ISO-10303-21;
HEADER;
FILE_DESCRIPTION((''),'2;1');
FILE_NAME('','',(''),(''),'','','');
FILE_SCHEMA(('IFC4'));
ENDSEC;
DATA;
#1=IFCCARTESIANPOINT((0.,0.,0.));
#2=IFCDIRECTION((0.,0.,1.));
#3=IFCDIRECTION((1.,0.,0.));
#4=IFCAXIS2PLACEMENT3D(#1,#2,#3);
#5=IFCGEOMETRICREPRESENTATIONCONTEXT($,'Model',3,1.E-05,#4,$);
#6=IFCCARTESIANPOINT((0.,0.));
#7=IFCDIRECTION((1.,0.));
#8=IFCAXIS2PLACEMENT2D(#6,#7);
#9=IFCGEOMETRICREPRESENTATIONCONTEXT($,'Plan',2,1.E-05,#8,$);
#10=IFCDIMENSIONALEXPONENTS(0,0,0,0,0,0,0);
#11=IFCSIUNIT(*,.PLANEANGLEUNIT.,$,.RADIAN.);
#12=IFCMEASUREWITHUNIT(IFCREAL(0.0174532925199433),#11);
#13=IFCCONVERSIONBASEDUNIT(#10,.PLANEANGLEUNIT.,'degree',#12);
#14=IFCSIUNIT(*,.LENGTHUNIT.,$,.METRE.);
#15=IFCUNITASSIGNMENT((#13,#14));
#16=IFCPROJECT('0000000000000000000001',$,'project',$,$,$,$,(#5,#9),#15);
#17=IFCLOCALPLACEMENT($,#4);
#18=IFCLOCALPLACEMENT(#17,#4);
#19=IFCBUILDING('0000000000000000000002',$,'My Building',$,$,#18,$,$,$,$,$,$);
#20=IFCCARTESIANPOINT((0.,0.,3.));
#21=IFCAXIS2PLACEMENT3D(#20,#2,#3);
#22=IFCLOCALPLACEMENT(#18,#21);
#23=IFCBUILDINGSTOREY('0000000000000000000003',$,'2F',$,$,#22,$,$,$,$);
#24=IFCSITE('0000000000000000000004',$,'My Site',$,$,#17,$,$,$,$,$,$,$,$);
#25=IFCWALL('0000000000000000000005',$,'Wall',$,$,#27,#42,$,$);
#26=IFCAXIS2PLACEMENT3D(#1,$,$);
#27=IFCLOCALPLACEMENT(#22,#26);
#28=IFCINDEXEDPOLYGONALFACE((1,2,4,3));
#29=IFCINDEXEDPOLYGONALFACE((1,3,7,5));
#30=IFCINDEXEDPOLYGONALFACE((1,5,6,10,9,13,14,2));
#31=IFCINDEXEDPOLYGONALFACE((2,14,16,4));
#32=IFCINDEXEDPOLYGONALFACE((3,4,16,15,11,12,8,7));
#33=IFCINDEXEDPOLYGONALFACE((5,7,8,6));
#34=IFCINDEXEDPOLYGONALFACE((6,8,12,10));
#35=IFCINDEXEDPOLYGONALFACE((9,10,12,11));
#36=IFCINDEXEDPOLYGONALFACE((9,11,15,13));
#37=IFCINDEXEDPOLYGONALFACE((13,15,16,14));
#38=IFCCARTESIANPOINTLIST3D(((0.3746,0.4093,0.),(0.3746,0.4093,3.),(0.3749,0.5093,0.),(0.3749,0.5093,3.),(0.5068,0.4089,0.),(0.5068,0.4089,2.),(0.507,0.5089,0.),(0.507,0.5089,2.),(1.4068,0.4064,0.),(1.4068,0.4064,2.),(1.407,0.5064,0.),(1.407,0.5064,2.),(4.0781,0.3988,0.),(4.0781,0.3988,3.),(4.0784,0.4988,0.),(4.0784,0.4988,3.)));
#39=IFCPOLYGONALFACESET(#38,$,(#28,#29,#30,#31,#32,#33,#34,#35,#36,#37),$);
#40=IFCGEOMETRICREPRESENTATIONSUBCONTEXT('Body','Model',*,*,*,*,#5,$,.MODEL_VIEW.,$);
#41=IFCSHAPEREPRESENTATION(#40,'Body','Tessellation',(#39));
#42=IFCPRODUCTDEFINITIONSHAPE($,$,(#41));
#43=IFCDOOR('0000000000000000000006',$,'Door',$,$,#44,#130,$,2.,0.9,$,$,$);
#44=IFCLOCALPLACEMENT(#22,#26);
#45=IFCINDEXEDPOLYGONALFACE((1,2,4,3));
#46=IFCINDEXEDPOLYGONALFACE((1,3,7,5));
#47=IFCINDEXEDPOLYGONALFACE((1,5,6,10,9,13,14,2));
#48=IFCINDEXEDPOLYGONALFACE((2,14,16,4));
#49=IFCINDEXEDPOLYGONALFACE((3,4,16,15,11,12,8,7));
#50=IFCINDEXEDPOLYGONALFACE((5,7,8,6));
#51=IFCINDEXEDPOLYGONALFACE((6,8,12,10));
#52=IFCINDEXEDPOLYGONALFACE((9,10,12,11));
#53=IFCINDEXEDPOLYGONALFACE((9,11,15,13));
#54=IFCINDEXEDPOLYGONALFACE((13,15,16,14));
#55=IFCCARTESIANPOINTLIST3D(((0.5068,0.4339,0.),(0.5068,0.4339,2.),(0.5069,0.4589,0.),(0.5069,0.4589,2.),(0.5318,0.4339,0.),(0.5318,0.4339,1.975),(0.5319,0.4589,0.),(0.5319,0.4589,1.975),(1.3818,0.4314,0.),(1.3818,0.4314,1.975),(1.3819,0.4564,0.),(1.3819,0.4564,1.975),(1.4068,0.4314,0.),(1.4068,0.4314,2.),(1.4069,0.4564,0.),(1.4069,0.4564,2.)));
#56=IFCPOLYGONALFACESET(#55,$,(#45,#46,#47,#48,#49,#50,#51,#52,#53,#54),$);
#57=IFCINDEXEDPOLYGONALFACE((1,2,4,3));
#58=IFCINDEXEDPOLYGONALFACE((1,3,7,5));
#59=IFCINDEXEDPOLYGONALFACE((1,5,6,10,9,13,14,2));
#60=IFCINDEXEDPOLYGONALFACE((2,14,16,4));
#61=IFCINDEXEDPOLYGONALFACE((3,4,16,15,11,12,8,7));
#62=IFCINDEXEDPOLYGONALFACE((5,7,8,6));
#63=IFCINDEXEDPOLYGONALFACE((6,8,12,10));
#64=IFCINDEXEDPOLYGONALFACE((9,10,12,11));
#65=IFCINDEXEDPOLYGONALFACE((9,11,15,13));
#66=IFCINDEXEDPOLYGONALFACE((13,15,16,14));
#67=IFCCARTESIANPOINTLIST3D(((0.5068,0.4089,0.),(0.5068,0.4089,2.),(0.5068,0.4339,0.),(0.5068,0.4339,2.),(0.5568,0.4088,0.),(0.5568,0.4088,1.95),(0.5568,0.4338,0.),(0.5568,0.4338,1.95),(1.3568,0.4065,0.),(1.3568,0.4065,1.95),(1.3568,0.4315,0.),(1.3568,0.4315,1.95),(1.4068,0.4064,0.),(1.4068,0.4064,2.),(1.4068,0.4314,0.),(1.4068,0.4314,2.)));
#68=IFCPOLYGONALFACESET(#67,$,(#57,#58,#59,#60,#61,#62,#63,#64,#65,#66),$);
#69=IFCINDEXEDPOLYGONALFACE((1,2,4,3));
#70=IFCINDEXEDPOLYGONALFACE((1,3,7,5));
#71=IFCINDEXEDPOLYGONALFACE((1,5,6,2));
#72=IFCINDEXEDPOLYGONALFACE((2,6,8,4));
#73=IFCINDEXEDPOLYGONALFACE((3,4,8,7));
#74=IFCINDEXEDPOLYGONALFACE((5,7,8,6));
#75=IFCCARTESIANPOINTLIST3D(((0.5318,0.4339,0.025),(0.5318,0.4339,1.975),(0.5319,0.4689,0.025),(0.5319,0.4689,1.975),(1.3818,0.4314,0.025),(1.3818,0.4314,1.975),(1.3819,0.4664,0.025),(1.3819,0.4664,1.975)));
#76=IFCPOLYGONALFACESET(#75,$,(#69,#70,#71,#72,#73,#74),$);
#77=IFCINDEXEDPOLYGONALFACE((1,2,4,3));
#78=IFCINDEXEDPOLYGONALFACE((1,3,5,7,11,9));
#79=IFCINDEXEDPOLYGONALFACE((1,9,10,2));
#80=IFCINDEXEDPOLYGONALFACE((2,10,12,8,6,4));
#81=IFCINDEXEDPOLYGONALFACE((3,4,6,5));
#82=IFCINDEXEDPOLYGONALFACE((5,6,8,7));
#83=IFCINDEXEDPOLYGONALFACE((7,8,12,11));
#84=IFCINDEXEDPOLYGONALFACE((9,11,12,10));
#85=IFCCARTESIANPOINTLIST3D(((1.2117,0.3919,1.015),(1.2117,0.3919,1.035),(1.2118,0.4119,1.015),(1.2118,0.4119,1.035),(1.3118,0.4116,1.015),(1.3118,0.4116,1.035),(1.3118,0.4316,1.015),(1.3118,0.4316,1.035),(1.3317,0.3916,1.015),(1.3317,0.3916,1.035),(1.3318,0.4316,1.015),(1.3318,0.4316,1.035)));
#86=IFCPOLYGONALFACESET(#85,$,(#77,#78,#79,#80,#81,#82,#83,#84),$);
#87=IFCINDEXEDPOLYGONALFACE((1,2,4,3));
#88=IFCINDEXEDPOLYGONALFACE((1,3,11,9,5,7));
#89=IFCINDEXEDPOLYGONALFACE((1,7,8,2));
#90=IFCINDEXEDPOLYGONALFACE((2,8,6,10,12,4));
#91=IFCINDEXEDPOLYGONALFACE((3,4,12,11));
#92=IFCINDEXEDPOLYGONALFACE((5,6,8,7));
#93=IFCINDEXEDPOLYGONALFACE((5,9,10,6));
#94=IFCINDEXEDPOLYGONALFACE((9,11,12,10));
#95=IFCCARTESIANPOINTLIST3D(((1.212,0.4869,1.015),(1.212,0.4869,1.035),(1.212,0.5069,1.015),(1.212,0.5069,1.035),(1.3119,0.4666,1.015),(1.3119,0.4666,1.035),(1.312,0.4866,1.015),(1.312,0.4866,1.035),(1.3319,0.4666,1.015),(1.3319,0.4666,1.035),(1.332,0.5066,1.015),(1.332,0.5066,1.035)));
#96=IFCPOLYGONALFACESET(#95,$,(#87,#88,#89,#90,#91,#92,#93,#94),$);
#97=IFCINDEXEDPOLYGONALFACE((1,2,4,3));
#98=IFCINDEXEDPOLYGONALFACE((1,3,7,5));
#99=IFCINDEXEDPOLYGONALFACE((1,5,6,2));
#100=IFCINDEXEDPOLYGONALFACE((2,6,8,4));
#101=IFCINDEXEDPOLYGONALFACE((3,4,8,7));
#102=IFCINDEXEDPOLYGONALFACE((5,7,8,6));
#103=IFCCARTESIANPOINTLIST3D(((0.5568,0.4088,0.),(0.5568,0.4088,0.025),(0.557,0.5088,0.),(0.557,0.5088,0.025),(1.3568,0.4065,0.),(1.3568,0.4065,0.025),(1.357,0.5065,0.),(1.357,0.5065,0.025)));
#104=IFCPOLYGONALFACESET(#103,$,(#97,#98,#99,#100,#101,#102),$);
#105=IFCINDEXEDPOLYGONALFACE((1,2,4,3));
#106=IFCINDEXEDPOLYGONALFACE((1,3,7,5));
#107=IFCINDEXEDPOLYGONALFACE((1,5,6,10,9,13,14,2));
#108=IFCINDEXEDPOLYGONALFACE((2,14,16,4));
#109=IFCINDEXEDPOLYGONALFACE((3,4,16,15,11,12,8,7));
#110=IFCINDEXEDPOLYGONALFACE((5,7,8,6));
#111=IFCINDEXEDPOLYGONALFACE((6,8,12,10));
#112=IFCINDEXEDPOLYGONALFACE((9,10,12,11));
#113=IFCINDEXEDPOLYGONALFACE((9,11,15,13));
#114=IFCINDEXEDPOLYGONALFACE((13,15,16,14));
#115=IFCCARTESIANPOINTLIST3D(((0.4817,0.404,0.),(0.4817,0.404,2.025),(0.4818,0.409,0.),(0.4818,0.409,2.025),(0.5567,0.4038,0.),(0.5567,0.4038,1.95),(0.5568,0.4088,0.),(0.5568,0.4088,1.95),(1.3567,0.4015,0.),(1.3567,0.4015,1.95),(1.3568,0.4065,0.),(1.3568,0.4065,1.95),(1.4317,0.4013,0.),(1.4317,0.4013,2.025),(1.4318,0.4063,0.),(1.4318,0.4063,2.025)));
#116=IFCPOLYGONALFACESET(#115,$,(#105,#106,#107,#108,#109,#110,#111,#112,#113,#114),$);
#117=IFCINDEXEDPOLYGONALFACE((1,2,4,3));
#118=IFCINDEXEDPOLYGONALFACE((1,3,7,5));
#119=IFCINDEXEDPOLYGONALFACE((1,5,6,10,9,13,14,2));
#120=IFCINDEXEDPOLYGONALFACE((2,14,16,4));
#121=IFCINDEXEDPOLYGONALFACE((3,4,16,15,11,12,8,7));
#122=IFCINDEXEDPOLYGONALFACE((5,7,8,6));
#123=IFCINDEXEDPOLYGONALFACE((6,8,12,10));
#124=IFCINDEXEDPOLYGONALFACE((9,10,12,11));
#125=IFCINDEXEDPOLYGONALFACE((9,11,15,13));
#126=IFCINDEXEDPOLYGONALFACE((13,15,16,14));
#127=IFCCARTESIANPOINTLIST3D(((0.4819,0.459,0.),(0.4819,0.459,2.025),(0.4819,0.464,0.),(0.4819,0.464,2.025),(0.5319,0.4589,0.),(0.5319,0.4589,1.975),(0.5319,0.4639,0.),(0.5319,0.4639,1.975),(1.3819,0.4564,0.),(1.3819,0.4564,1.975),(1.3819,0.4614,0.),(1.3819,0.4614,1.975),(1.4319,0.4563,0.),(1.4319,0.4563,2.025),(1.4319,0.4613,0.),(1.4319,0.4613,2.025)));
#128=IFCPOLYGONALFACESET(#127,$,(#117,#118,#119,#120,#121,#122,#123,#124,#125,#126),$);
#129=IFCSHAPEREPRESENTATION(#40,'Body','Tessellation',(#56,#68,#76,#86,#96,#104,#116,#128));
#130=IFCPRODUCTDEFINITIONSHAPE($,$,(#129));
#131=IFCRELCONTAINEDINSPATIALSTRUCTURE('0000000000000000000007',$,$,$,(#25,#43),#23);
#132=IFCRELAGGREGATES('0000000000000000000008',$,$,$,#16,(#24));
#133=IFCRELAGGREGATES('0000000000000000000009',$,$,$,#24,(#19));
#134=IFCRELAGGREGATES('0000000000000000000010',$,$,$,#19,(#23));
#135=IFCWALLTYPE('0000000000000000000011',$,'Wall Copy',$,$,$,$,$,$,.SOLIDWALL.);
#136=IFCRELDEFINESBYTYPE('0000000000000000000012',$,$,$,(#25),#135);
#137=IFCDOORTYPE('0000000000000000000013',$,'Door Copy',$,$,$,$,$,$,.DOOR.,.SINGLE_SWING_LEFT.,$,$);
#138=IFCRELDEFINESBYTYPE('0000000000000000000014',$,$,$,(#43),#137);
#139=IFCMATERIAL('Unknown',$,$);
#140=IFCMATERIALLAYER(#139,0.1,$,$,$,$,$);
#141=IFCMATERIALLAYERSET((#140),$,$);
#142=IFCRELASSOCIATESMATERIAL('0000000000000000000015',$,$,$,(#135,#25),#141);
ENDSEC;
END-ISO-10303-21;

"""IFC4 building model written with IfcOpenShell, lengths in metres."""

from ifc_helpers import new_model, entity, si_unit, converted_unit, frame, origin_with_axes, origin_2d_with_axis, place, context, subcontext, project, spatial, line, indexed_curve, outline, extrude, shape, source, transform, mapped, material, layer, layer_set, layer_usage, type_object, type_shapes, element, fill, save


model = new_model("IFC4")

# Units and contexts
model_context = context("Model", 3, precision=1e-05, world=origin_with_axes())
plan_context = context("Plan", 2, precision=1e-05, world=origin_2d_with_axis())
body_context_1 = subcontext(model_context, "Body", "Model", "MODEL_VIEW")
body_context_2 = subcontext(plan_context, "Body", "Plan", "PLAN_VIEW")
ifc_project = project(units=[converted_unit("PLANEANGLEUNIT", "degree", entity("IfcReal", 0.0174532925199433), si_unit("PLANEANGLEUNIT", "RADIAN"), dimensions=[0, 0, 0, 0, 0, 0, 0]), si_unit("LENGTHUNIT", "METRE")], contexts=[model_context, plan_context])

# Site, building, storey
site_placement = place(None, origin_with_axes())
site = spatial("IfcSite", under=ifc_project, at=site_placement, Name="My Site")
building_placement = place(site_placement, origin_with_axes())
building = spatial("IfcBuilding", under=site, at=building_placement, Name="My Building")
storey_placement = place(building_placement, frame((0.0, 0.0, 3.0), z_axis=(0.0, 0.0, 1.0), x_axis=(1.0, 0.0, 0.0)))
storey = spatial("IfcBuildingStorey", under=building, at=storey_placement, Name="2F")

# Shared definitions
ifc_material = material(Name="Unknown")
ifc_layer_1 = layer(ifc_material, 0.1)
ifc_layer_set_1 = layer_set([ifc_layer_1])
wall_type_1 = type_object("IfcWallType", Name="Wall Copy", PredefinedType="SOLIDWALL", material=ifc_layer_set_1)

# Shared definitions
shared_shape_1 = source(origin_with_axes(), body_context_1, "Body", "SweptSolid", [
    extrude(outline(indexed_curve([(0.0, 0.0), (0.9, 0.0), (0.9, 2.0), (0.0, 2.0)], segments=[line(1, 2, 3, 4, 1)])), frame((0.0, -0.6, 0.0), z_axis=(0.0, -1.0, 0.0), x_axis=(1.0, 0.0, 0.0)), (0.0, 0.0, -1.0), 1.2),
])
door_type = type_object("IfcDoorType", Name="Door Copy", OperationType="SINGLE_SWING_LEFT", PredefinedType="DOOR")
shared_shape_2 = source(origin_with_axes(), body_context_1, "Body", "SweptSolid", [
    extrude(outline(indexed_curve([(0.0, 0.0), (0.0, 2.0), (0.9, 2.0), (0.9, 0.0), (0.875, 0.0), (0.875, 1.975), (0.025, 1.975), (0.025, 0.0)], segments=[line(1, 2, 3, 4, 5, 6, 7, 8, 1)])), frame((0.0, 0.025, 0.0), z_axis=(0.0, -1.0, 0.0), x_axis=(1.0, 0.0, 0.0)), (0.0, 0.0, -1.0), 0.025),
    extrude(outline(indexed_curve([(0.0, 0.0), (0.0, 2.0), (0.9, 2.0), (0.9, 0.0), (0.85, 0.0), (0.85, 1.95), (0.05, 1.95), (0.05, 0.0)], segments=[line(1, 2, 3, 4, 5, 6, 7, 8, 1)])), frame((0.0, 0.0, 0.0), z_axis=(0.0, -1.0, 0.0), x_axis=(1.0, 0.0, 0.0)), (0.0, 0.0, -1.0), 0.025),
    extrude(outline(indexed_curve([(0.0, 0.0), (0.85, 0.0), (0.85, 0.035), (0.0, 0.035)], segments=[line(1, 2, 3, 4, 1)])), frame((0.025, 0.025, 0.025), z_axis=(0.0, 0.0, 1.0), x_axis=(1.0, 0.0, 0.0)), (0.0, 0.0, 1.0), 1.95),
    extrude(outline(indexed_curve([(0.0, 0.0), (0.0, -0.04), (-0.12, -0.04), (-0.12, -0.02), (-0.02, -0.02), (-0.02, 0.0)], segments=[line(1, 2, 3, 4, 5, 6, 1)])), frame((0.825, 0.025, 1.015), z_axis=(0.0, 0.0, 1.0), x_axis=(1.0, 0.0, 0.0)), (0.0, 0.0, 1.0), 0.02),
    extrude(outline(indexed_curve([(0.0, 0.0), (0.0, 0.04), (-0.12, 0.04), (-0.12, 0.02), (-0.02, 0.02), (-0.02, 0.0)], segments=[line(1, 2, 3, 4, 5, 6, 1)])), frame((0.825, 0.06, 1.015), z_axis=(0.0, 0.0, 1.0), x_axis=(1.0, 0.0, 0.0)), (0.0, 0.0, 1.0), 0.02),
    extrude(outline(indexed_curve([(0.0, 0.0), (0.8, 0.0), (0.8, 0.1), (0.0, 0.1)], segments=[line(1, 2, 3, 4, 1)])), frame((0.05, 0.0, 0.0), z_axis=(0.0, 0.0, 1.0), x_axis=(1.0, 0.0, 0.0)), (0.0, 0.0, 1.0), 0.025),
    extrude(outline(indexed_curve([(0.0, 0.0), (0.0, 2.025), (0.95, 2.025), (0.95, 0.0), (0.875, 0.0), (0.875, 1.95), (0.075, 1.95), (0.075, 0.0)], segments=[line(1, 2, 3, 4, 5, 6, 7, 8, 1)])), frame((-0.025, -0.005, 0.0), z_axis=(0.0, -1.0, 0.0), x_axis=(1.0, 0.0, 0.0)), (0.0, 0.0, -1.0), 0.005),
    extrude(outline(indexed_curve([(0.0, 0.0), (0.0, 2.025), (0.95, 2.025), (0.95, 0.0), (0.9, 0.0), (0.9, 1.975), (0.05, 1.975), (0.05, 0.0)], segments=[line(1, 2, 3, 4, 5, 6, 7, 8, 1)])), frame((-0.025, 0.05, 0.0), z_axis=(0.0, -1.0, 0.0), x_axis=(1.0, 0.0, 0.0)), (0.0, 0.0, -1.0), 0.005),
])
shared_shape_3 = source(origin_with_axes(), body_context_2, "Body", "Curve2D", [
    entity("IfcIndexedPolyCurve", entity("IfcCartesianPointList2D", [[0.0, 0.0], [0.0, 0.05], [0.025, 0.05], [0.025, 0.025], [0.05, 0.025], [0.05, 0.0]]), [entity("IfcLineIndex", [1, 2, 3, 4, 5, 6, 1])]),
    entity("IfcIndexedPolyCurve", entity("IfcCartesianPointList2D", [[0.9, 0.0], [0.9, 0.05], [0.875, 0.05], [0.875, 0.025], [0.85, 0.025], [0.85, 0.0]]), [entity("IfcLineIndex", [1, 2, 3, 4, 5, 6, 1])]),
    entity("IfcTrimmedCurve", entity("IfcEllipse", entity("IfcAxis2Placement2D", entity("IfcCartesianPoint", [0.06, 0.05]), entity("IfcDirection", [1.0, 0.0])), 0.815, 0.85), [entity("IfcCartesianPoint", [0.875, 0.05])], [entity("IfcCartesianPoint", [0.06, 0.9])], True, "CARTESIAN"),
    entity("IfcIndexedPolyCurve", entity("IfcCartesianPointList2D", [[0.025, 0.05], [0.06, 0.05], [0.06, 0.9], [0.025, 0.9]]), [entity("IfcLineIndex", [1, 2, 3, 4, 1])]),
])
type_shapes(door_type, [shared_shape_2, shared_shape_3])

# Wall, opening, door
ifc_layer_usage_1 = layer_usage(ifc_layer_set_1, "AXIS2", "POSITIVE", 0.0)
wall_1_placement = place(storey_placement, frame((0.3746, 0.4093, 0.0), z_axis=(0.0, 0.0, 1.0), x_axis=(0.999996, -0.002846, 0.0)))
wall_1 = element("IfcWall", 1, at=wall_1_placement, inside=storey, type_object=wall_type_1, material=ifc_layer_usage_1, Name="Wall", context=body_context_1, shape_type="SweptSolid", body=[
    extrude(outline(indexed_curve([(0.0, 0.0), (0.0, 0.1), (3.7035, 0.1), (3.7035, 0.0)], segments=[line(1, 2, 3, 4, 1)])), origin_with_axes(), (0.0, 0.0, 1.0), 3.0),
])
opening_1_placement = place(wall_1_placement, frame((0.1321, 0.0, 0.0), z_axis=(0.0, 0.0, 1.0), x_axis=(1.0, 0.0, 0.0)))
opening_1 = element("IfcOpeningElement", 2, at=opening_1_placement, cuts=wall_1, PredefinedType="OPENING", context=body_context_1, shape_type="MappedRepresentation", body=[
    mapped(shared_shape_1, transform((0.0, 0.0, 0.0), x_axis=(1.0, 0.0, 0.0), y_axis=(0.0, 1.0, 0.0), z_axis=(0.0, 0.0, 1.0), scale=1.0)),
])
door_1_placement = place(opening_1_placement, frame((0.0, 0.0, 0.0), z_axis=(0.0, 0.0, 1.0), x_axis=(1.0, 0.0, 0.0)))
door_1 = element("IfcDoor", 3, at=door_1_placement, inside=storey, type_object=door_type, Name="Door", OverallHeight=2.0, OverallWidth=0.9, shapes=[
    shape(body_context_1, "Body", "MappedRepresentation", [mapped(shared_shape_2, transform((0.0, 0.0, 0.0), x_axis=(1.0, 0.0, 0.0), y_axis=(0.0, 1.0, 0.0), z_axis=(0.0, 0.0, 1.0), scale=1.0))]),
    shape(body_context_2, "Body", "MappedRepresentation", [mapped(shared_shape_3, transform((0.0, 0.0, 0.0), x_axis=(1.0, 0.0, 0.0), y_axis=(0.0, 1.0, 0.0), z_axis=(0.0, 0.0, 1.0), scale=1.0))]),
])
fill(opening_1, door_1)

save(model, "model.ifc")
